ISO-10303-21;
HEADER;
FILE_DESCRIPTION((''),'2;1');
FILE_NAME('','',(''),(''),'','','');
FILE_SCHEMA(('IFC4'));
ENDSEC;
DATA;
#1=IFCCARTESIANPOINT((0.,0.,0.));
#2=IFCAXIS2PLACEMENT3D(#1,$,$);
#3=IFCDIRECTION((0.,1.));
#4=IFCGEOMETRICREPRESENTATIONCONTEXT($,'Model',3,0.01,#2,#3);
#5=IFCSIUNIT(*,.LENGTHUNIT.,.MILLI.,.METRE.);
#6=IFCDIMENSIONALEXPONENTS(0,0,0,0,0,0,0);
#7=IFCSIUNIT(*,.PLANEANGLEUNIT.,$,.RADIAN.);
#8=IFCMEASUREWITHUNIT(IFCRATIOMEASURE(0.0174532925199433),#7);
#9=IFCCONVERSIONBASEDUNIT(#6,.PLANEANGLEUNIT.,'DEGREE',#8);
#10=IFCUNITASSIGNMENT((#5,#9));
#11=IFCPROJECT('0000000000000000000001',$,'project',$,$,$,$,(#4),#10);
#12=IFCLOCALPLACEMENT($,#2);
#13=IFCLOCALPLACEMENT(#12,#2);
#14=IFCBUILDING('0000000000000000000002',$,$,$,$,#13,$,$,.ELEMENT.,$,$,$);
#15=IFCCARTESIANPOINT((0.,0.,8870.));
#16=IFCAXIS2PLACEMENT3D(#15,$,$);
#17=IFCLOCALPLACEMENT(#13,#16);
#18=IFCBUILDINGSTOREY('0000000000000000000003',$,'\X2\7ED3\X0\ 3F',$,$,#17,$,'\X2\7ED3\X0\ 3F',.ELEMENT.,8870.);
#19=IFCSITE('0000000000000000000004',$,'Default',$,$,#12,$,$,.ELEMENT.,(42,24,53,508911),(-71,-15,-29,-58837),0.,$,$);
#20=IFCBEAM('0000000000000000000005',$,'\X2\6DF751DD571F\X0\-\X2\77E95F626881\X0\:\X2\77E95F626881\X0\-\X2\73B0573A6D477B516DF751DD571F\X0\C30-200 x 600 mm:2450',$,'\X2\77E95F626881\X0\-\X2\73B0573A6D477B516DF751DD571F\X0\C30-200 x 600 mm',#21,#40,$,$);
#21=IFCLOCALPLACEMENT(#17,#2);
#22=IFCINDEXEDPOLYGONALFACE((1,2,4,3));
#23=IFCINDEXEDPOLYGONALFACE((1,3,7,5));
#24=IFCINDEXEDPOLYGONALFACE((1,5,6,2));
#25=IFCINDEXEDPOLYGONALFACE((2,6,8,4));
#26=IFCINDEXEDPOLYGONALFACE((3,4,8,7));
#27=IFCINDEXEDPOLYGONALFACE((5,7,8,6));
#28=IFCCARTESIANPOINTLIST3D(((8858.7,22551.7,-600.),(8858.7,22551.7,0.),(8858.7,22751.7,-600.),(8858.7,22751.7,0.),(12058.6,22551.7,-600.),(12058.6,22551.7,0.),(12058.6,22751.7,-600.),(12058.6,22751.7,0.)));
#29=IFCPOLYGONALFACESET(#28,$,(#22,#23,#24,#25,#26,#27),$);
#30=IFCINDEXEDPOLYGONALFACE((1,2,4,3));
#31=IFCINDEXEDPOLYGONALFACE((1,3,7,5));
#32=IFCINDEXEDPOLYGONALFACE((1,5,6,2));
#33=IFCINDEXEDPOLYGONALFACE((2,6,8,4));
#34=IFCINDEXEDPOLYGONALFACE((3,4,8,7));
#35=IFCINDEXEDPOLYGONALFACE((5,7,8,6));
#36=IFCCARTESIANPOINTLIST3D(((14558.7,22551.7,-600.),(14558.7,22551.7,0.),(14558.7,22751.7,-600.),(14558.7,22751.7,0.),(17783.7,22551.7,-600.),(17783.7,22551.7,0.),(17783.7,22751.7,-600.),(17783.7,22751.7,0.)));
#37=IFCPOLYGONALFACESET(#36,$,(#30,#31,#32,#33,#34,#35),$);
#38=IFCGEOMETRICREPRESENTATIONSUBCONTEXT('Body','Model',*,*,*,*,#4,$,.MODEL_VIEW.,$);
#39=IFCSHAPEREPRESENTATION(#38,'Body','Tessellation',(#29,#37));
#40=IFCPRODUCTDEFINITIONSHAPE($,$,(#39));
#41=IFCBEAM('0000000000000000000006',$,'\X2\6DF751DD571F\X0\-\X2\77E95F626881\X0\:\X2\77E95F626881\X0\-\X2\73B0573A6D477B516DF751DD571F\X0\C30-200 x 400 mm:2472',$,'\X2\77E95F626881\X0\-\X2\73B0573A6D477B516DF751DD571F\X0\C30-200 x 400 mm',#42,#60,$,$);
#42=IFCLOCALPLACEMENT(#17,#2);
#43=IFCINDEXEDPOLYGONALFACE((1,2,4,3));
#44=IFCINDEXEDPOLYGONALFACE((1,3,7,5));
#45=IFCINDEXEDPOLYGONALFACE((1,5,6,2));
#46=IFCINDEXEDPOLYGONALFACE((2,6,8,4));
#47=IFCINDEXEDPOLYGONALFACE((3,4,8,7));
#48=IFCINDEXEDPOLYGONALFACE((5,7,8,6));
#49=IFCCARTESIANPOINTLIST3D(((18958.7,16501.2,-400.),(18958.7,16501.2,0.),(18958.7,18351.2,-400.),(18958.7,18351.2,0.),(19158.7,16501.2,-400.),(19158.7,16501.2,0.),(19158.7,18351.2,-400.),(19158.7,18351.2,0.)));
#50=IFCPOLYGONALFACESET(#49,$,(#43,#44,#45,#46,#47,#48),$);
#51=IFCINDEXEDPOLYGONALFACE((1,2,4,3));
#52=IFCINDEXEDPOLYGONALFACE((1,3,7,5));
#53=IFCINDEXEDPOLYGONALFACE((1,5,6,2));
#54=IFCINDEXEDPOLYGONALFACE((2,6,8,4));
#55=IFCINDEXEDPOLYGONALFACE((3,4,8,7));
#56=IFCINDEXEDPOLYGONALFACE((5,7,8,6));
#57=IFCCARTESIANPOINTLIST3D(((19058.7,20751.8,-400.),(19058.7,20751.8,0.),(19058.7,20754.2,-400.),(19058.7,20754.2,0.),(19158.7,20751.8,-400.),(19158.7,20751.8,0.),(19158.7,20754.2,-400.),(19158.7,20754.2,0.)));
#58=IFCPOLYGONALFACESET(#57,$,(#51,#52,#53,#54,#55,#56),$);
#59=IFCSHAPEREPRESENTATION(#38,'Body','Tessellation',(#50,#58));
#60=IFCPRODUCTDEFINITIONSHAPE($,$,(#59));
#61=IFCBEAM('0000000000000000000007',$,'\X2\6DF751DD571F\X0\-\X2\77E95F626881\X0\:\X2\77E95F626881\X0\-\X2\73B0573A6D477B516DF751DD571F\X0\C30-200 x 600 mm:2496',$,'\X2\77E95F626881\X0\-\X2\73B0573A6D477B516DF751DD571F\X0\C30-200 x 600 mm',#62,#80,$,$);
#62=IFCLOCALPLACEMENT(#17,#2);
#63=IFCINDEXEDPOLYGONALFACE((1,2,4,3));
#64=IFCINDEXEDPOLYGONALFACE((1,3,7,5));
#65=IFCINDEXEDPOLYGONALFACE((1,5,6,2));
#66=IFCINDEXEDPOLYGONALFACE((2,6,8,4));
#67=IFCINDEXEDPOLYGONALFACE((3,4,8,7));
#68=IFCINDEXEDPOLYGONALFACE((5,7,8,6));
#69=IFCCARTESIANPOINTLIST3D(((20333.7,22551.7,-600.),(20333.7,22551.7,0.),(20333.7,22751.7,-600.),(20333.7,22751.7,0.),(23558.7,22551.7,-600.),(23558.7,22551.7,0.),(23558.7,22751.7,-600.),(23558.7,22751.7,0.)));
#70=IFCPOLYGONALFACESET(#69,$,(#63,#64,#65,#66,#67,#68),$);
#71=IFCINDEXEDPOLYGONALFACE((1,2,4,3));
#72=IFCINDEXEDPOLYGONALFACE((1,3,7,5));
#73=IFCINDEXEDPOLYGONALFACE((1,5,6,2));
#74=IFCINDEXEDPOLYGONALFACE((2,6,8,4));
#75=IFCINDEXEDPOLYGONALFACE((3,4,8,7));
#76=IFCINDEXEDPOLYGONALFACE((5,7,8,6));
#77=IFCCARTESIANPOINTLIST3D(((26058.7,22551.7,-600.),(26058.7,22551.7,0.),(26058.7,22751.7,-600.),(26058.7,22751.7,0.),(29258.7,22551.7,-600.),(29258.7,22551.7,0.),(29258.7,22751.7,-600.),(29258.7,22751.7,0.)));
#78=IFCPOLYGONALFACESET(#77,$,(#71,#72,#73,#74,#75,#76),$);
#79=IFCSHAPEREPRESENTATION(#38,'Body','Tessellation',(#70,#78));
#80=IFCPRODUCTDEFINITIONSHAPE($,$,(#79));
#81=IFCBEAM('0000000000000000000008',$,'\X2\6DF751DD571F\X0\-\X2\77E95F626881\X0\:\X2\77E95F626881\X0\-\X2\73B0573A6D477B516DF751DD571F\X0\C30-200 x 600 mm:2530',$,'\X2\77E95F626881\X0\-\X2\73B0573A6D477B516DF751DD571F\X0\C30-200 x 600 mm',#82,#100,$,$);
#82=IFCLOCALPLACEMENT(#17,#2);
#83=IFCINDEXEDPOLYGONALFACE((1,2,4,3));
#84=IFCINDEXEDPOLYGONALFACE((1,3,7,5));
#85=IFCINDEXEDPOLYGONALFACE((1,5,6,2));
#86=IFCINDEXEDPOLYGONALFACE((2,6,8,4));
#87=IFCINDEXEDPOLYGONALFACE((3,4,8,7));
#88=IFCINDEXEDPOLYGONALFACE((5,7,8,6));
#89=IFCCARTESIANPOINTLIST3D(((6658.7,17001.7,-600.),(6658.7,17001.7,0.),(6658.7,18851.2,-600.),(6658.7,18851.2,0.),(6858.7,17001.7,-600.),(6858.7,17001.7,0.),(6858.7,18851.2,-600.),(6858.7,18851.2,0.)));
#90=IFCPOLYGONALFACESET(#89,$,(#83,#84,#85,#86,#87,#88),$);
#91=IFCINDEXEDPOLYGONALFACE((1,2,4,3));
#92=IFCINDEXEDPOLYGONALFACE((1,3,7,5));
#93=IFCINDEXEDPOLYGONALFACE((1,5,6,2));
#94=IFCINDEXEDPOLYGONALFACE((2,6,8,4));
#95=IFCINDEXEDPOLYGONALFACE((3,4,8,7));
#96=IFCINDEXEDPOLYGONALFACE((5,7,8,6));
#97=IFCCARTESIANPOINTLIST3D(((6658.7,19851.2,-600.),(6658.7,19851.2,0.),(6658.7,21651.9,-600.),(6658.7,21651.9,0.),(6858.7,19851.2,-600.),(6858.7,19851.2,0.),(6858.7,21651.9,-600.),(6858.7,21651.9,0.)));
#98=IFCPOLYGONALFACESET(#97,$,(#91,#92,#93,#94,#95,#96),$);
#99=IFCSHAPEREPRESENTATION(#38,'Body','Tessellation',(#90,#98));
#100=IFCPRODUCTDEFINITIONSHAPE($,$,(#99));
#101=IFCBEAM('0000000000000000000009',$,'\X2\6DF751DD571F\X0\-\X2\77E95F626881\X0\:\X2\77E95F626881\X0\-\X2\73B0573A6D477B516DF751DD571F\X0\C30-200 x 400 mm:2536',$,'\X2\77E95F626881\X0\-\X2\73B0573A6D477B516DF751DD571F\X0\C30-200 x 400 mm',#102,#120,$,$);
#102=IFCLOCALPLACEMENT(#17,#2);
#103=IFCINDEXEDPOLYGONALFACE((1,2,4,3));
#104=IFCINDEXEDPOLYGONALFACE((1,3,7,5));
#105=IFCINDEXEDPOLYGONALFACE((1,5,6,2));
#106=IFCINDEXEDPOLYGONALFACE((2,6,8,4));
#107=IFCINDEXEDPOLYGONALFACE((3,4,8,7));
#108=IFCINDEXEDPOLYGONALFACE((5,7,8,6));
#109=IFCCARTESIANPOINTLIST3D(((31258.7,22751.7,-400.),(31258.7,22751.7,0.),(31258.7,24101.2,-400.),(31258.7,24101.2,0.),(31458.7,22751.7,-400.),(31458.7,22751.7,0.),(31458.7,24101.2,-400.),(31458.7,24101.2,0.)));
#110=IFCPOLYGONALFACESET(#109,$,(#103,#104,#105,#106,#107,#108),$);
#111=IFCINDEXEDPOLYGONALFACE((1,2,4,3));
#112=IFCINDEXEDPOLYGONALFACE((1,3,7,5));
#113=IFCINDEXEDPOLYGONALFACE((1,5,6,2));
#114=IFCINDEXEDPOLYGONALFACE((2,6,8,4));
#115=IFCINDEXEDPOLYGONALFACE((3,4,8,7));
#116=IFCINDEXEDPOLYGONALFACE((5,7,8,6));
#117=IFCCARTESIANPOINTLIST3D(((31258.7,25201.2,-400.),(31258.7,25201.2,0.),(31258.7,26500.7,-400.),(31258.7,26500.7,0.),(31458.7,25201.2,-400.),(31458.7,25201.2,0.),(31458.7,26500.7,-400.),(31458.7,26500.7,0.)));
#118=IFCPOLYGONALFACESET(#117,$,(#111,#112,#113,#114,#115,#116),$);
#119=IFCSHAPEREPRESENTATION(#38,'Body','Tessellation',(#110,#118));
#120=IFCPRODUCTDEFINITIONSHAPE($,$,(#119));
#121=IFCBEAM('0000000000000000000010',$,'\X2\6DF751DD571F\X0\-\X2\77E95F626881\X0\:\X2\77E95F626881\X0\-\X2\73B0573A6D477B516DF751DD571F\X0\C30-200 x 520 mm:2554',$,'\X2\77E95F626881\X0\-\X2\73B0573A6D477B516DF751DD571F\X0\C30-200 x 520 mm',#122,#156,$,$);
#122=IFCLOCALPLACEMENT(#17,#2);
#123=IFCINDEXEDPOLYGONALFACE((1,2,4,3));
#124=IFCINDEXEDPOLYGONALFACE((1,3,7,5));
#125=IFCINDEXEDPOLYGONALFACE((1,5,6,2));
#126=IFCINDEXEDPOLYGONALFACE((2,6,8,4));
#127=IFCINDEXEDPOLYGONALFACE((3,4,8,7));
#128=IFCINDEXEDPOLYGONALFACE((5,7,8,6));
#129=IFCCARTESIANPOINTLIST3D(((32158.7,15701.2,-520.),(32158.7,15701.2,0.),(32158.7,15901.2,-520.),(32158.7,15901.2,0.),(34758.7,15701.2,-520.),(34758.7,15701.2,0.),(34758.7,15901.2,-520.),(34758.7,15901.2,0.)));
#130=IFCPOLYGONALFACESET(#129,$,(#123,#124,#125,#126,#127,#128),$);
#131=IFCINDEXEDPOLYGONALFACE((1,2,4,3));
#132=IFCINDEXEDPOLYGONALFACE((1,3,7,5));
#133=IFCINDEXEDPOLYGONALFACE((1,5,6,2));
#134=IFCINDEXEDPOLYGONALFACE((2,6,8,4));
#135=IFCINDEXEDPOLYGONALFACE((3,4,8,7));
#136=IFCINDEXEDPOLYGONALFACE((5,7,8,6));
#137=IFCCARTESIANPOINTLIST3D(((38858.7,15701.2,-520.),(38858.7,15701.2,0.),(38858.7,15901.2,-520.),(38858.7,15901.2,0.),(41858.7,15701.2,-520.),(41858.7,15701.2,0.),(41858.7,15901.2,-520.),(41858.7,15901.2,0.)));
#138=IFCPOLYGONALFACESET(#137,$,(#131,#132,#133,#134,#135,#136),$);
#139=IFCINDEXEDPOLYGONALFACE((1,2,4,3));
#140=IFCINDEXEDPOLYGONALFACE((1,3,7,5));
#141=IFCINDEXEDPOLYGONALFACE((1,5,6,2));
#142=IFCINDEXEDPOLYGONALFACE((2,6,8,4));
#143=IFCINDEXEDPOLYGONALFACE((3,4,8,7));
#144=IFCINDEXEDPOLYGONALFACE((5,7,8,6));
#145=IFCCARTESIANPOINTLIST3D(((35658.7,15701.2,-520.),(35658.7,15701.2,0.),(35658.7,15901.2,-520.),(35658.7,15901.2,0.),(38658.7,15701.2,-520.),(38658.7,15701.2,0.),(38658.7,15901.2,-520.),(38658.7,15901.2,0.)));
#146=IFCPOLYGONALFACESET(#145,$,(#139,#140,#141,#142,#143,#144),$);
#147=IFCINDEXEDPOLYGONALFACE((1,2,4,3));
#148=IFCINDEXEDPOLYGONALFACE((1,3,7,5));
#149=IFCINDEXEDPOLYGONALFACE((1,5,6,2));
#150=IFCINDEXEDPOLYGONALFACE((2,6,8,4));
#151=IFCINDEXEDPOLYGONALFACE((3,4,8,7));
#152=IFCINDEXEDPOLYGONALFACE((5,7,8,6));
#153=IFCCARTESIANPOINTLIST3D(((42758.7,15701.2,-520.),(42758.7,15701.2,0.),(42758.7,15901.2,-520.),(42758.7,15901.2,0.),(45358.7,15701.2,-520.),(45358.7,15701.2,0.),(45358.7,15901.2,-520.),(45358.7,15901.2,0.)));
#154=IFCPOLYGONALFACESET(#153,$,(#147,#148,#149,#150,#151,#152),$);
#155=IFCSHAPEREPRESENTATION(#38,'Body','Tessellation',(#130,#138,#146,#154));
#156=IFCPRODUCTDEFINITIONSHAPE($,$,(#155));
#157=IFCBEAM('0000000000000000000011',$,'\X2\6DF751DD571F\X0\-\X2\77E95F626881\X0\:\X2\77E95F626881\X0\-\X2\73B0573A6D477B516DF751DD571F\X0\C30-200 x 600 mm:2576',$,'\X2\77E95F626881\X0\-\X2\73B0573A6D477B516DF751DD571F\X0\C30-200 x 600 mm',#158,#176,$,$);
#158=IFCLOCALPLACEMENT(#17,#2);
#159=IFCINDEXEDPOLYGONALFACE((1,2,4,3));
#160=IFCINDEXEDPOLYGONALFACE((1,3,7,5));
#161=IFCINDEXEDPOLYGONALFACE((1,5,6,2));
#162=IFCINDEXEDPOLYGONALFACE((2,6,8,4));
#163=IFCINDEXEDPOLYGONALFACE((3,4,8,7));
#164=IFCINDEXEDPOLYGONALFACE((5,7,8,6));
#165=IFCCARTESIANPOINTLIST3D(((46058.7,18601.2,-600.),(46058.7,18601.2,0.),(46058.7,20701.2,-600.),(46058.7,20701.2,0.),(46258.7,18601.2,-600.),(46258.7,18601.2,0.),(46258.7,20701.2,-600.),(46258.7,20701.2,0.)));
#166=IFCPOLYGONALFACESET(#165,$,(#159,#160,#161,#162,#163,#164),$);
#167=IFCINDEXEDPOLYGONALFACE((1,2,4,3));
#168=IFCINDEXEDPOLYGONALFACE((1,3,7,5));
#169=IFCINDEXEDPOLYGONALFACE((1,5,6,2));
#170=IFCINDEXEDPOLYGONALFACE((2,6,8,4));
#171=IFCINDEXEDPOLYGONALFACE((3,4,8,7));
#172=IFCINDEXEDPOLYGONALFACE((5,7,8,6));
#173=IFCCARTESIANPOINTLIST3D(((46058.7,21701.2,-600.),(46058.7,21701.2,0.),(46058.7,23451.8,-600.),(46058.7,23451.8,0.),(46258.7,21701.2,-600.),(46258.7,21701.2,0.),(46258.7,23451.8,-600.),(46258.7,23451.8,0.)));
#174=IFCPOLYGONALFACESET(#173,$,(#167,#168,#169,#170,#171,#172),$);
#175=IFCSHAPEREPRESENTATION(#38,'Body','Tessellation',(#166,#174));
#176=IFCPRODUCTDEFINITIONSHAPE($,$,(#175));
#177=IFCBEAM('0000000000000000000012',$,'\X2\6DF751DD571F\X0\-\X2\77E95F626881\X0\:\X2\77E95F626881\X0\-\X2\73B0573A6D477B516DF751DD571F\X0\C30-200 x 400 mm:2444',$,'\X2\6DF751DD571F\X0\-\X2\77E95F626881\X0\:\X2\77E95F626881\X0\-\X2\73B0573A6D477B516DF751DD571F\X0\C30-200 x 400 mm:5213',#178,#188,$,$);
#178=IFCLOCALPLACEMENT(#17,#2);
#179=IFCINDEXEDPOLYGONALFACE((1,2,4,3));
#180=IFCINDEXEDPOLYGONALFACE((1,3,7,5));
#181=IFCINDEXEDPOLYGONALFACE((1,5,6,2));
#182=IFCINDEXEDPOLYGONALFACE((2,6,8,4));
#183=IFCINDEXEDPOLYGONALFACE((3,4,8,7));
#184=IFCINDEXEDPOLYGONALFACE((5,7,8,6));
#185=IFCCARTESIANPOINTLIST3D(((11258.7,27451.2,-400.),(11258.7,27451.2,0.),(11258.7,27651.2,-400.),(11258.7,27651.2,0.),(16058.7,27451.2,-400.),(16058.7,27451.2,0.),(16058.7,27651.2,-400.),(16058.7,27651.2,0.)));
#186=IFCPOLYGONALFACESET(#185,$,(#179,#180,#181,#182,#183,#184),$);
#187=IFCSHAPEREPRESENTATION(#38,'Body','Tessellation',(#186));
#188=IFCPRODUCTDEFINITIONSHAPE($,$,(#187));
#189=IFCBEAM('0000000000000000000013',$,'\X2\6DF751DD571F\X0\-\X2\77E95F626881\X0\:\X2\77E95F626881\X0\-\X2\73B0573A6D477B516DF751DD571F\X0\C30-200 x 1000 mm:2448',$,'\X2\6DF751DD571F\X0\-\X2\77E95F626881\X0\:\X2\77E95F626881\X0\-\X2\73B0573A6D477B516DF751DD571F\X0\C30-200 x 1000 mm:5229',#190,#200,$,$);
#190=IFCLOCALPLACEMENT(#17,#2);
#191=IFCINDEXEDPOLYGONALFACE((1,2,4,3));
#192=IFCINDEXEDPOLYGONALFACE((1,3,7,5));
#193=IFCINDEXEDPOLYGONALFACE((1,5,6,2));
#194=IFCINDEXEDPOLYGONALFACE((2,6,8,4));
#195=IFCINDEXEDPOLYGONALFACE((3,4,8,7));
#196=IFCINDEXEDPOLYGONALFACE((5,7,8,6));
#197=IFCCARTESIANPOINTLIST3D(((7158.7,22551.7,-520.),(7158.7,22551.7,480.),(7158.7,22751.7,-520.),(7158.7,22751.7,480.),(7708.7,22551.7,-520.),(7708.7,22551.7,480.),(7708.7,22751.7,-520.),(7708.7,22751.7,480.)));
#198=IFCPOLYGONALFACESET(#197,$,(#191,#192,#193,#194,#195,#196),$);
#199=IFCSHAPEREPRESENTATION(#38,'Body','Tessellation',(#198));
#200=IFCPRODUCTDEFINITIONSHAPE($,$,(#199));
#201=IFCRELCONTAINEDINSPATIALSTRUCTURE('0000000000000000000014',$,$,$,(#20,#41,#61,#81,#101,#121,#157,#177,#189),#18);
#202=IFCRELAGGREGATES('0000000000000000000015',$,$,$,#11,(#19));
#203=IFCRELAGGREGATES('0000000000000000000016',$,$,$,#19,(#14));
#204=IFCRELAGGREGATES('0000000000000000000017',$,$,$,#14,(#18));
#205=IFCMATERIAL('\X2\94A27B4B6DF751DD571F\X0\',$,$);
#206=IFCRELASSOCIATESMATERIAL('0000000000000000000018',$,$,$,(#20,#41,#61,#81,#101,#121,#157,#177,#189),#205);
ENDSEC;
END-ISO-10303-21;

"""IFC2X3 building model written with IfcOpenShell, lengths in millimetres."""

from ifc_helpers import new_model, entity, si_unit, converted_unit, direction, frame, frame_2d, origin, origin_2d_with_axis, place, context, subcontext, project, spatial, rectangle, extrude, source, transform, mapped, material, element, save


model = new_model("IFC2X3")

# Units and contexts
model_context = context("Model", 3, precision=0.01, world=origin(), true_north=direction((0.0, 1.0)))
body_context = subcontext(model_context, "Body", "Model", "MODEL_VIEW")
ifc_project = project(units=[si_unit("LENGTHUNIT", "METRE", prefix="MILLI"), converted_unit("PLANEANGLEUNIT", "DEGREE", entity("IfcRatioMeasure", 0.0174532925199433), si_unit("PLANEANGLEUNIT", "RADIAN"), dimensions=[0, 0, 0, 0, 0, 0, 0])], contexts=[model_context])

# Site, building, storey
site_placement = place(None, origin())
site = spatial("IfcSite", under=ifc_project, at=site_placement, Name="Default", CompositionType="ELEMENT", RefLatitude=(42, 24, 53, 508911), RefLongitude=(-71, -15, -29, -58837), RefElevation=0.0)
building_placement = place(site_placement, origin())
building = spatial("IfcBuilding", under=site, at=building_placement, CompositionType="ELEMENT")
storey_placement = place(building_placement, frame((0.0, 0.0, 8870.0)))
storey = spatial("IfcBuildingStorey", under=building, at=storey_placement, Name="结 3F", LongName="结 3F", CompositionType="ELEMENT", Elevation=8870.0)

# Beams
ifc_material = material(Name="钢筋混凝土")
shared_shape_1 = source(origin(), body_context, "Body", "SweptSolid", [
    extrude(rectangle(XDim=3200.0, YDim=200.0, at=origin_2d_with_axis()), frame((10458.7, 22651.7, 8270.0), z_axis=(0.0, 0.0, 1.0), x_axis=(-1.0, 0.0, 0.0)), (0.0, 0.0, 1.0), 600.0),
    extrude(rectangle(XDim=3225.0, YDim=200.0, at=origin_2d_with_axis()), frame((16171.2, 22651.7, 8270.0), z_axis=(0.0, 0.0, 1.0), x_axis=(-1.0, 0.0, 0.0)), (0.0, 0.0, 1.0), 600.0),
])
beam_1_placement = place(storey_placement, frame((0.0, 0.0, -8870.0)))
element("IfcBeam", 1, at=beam_1_placement, inside=storey, material=ifc_material, Name="混凝土-矩形梁:矩形梁-现场浇筑混凝土C30-200 x 600 mm:2450", ObjectType="矩形梁-现场浇筑混凝土C30-200 x 600 mm", context=body_context, shape_type="MappedRepresentation", body=[
    mapped(shared_shape_1, transform((0.0, 0.0, 0.0), scale=1.0)),
])
shared_shape_2 = source(origin(), body_context, "Body", "SweptSolid", [
    extrude(rectangle(XDim=1850.0, YDim=200.0, at=frame_2d((0.0, 0.0), x_axis=(1.0, 0.0))), frame((19058.7, 17426.2, 8470.0), z_axis=(0.0, 0.0, 1.0), x_axis=(0.0, -1.0, 0.0)), (0.0, 0.0, 1.0), 400.0),
    extrude(rectangle(XDim=100.0, YDim=2.4, at=origin_2d_with_axis()), frame((19108.7, 20753.0, 8470.0), z_axis=(0.0, 0.0, 1.0), x_axis=(-1.0, 0.0, 0.0)), (0.0, 0.0, 1.0), 400.0),
])
beam_2_placement = place(storey_placement, frame((0.0, 0.0, -8870.0)))
element("IfcBeam", 2, at=beam_2_placement, inside=storey, material=ifc_material, Name="混凝土-矩形梁:矩形梁-现场浇筑混凝土C30-200 x 400 mm:2472", ObjectType="矩形梁-现场浇筑混凝土C30-200 x 400 mm", context=body_context, shape_type="MappedRepresentation", body=[
    mapped(shared_shape_2, transform((0.0, 0.0, 0.0), scale=1.0)),
])
shared_shape_3 = source(origin(), body_context, "Body", "SweptSolid", [
    extrude(rectangle(XDim=3225.0, YDim=200.0, at=origin_2d_with_axis()), frame((21946.2, 22651.7, 8270.0)), (0.0, 0.0, 1.0), 600.0),
    extrude(rectangle(XDim=3200.0, YDim=200.0, at=frame_2d((0.0, 0.0), x_axis=(1.0, 0.0))), frame((27658.7, 22651.7, 8270.0)), (0.0, 0.0, 1.0), 600.0),
])
beam_3_placement = place(storey_placement, frame((0.0, 0.0, -8870.0)))
element("IfcBeam", 3, at=beam_3_placement, inside=storey, material=ifc_material, Name="混凝土-矩形梁:矩形梁-现场浇筑混凝土C30-200 x 600 mm:2496", ObjectType="矩形梁-现场浇筑混凝土C30-200 x 600 mm", context=body_context, shape_type="MappedRepresentation", body=[
    mapped(shared_shape_3, transform((0.0, 0.0, 0.0), scale=1.0)),
])
shared_shape_4 = source(origin(), body_context, "Body", "SweptSolid", [
    extrude(rectangle(XDim=1849.5, YDim=200.0, at=frame_2d((0.0, 0.0), x_axis=(1.0, 0.0))), frame((6758.7, 17926.5, 8270.0), z_axis=(0.0, 0.0, 1.0), x_axis=(0.0, 1.0, 0.0)), (0.0, 0.0, 1.0), 600.0),
    extrude(rectangle(XDim=1800.7, YDim=200.0, at=frame_2d((0.0, 0.0), x_axis=(1.0, 0.0))), frame((6758.7, 20751.6, 8270.0), z_axis=(0.0, 0.0, 1.0), x_axis=(0.0, -1.0, 0.0)), (0.0, 0.0, 1.0), 600.0),
])
beam_4_placement = place(storey_placement, frame((0.0, 0.0, -8870.0)))
element("IfcBeam", 4, at=beam_4_placement, inside=storey, material=ifc_material, Name="混凝土-矩形梁:矩形梁-现场浇筑混凝土C30-200 x 600 mm:2530", ObjectType="矩形梁-现场浇筑混凝土C30-200 x 600 mm", context=body_context, shape_type="MappedRepresentation", body=[
    mapped(shared_shape_4, transform((0.0, 0.0, 0.0), scale=1.0)),
])
shared_shape_5 = source(origin(), body_context, "Body", "SweptSolid", [
    extrude(rectangle(XDim=1349.5, YDim=200.0, at=frame_2d((0.0, 0.0), x_axis=(1.0, 0.0))), frame((31358.7, 23426.5, 8470.0), z_axis=(0.0, 0.0, 1.0), x_axis=(0.0, 1.0, 0.0)), (0.0, 0.0, 1.0), 400.0),
    extrude(rectangle(XDim=1299.5, YDim=200.0, at=frame_2d((0.0, 0.0), x_axis=(1.0, 0.0))), frame((31358.7, 25851.0, 8470.0), z_axis=(0.0, 0.0, 1.0), x_axis=(0.0, -1.0, 0.0)), (0.0, 0.0, 1.0), 400.0),
])
beam_5_placement = place(storey_placement, frame((0.0, 0.0, -8870.0)))
element("IfcBeam", 5, at=beam_5_placement, inside=storey, material=ifc_material, Name="混凝土-矩形梁:矩形梁-现场浇筑混凝土C30-200 x 400 mm:2536", ObjectType="矩形梁-现场浇筑混凝土C30-200 x 400 mm", context=body_context, shape_type="MappedRepresentation", body=[
    mapped(shared_shape_5, transform((0.0, 0.0, 0.0), scale=1.0)),
])
shared_shape_6 = source(origin(), body_context, "Body", "SweptSolid", [
    extrude(rectangle(XDim=2600.0, YDim=200.0, at=frame_2d((0.0, 0.0), x_axis=(1.0, 0.0))), frame((33458.7, 15801.2, 8350.0), z_axis=(0.0, 0.0, 1.0), x_axis=(-1.0, 0.0, 0.0)), (0.0, 0.0, 1.0), 520.0),
    extrude(rectangle(XDim=3000.0, YDim=200.0, at=origin_2d_with_axis()), frame((40358.7, 15801.2, 8350.0)), (0.0, 0.0, 1.0), 520.0),
    extrude(rectangle(XDim=3000.0, YDim=200.0, at=frame_2d((0.0, 0.0), x_axis=(1.0, 0.0))), frame((37158.7, 15801.2, 8350.0), z_axis=(0.0, 0.0, 1.0), x_axis=(-1.0, 0.0, 0.0)), (0.0, 0.0, 1.0), 520.0),
    extrude(rectangle(XDim=2600.0, YDim=200.0, at=frame_2d((0.0, 0.0), x_axis=(1.0, 0.0))), frame((44058.7, 15801.2, 8350.0)), (0.0, 0.0, 1.0), 520.0),
])
beam_6_placement = place(storey_placement, frame((0.0, 0.0, -8870.0)))
element("IfcBeam", 6, at=beam_6_placement, inside=storey, material=ifc_material, Name="混凝土-矩形梁:矩形梁-现场浇筑混凝土C30-200 x 520 mm:2554", ObjectType="矩形梁-现场浇筑混凝土C30-200 x 520 mm", context=body_context, shape_type="MappedRepresentation", body=[
    mapped(shared_shape_6, transform((0.0, 0.0, 0.0), scale=1.0)),
])
shared_shape_7 = source(origin(), body_context, "Body", "SweptSolid", [
    extrude(rectangle(XDim=2100.0, YDim=200.0, at=frame_2d((0.0, 0.0), x_axis=(1.0, 0.0))), frame((46158.7, 19651.2, 8270.0), z_axis=(0.0, 0.0, 1.0), x_axis=(0.0, 1.0, 0.0)), (0.0, 0.0, 1.0), 600.0),
    extrude(rectangle(XDim=1750.6, YDim=200.0, at=frame_2d((0.0, 0.0), x_axis=(1.0, 0.0))), frame((46158.7, 22576.5, 8270.0), z_axis=(0.0, 0.0, 1.0), x_axis=(0.0, 1.0, 0.0)), (0.0, 0.0, 1.0), 600.0),
])
beam_7_placement = place(storey_placement, frame((0.0, 0.0, -8870.0)))
element("IfcBeam", 7, at=beam_7_placement, inside=storey, material=ifc_material, Name="混凝土-矩形梁:矩形梁-现场浇筑混凝土C30-200 x 600 mm:2576", ObjectType="矩形梁-现场浇筑混凝土C30-200 x 600 mm", context=body_context, shape_type="MappedRepresentation", body=[
    mapped(shared_shape_7, transform((0.0, 0.0, 0.0), scale=1.0)),
])
beam_8_placement = place(storey_placement, frame((11158.7, 27551.2, 0.0)))
element("IfcBeam", 8, at=beam_8_placement, inside=storey, material=ifc_material, Name="混凝土-矩形梁:矩形梁-现场浇筑混凝土C30-200 x 400 mm:2444", ObjectType="混凝土-矩形梁:矩形梁-现场浇筑混凝土C30-200 x 400 mm:5213", context=body_context, shape_type="SweptSolid", body=[
    extrude(rectangle(XDim=400.0, YDim=200.0, at=frame_2d((0.0, 0.0), x_axis=(1.0, 0.0))), frame((100.0, 0.0, -200.0), z_axis=(1.0, 0.0, 0.0), x_axis=(0.0, 0.0, -1.0)), (0.0, 0.0, 1.0), 4800.0),
])
beam_9_placement = place(storey_placement, frame((6758.7, 22651.7, 480.0)))
element("IfcBeam", 9, at=beam_9_placement, inside=storey, material=ifc_material, Name="混凝土-矩形梁:矩形梁-现场浇筑混凝土C30-200 x 1000 mm:2448", ObjectType="混凝土-矩形梁:矩形梁-现场浇筑混凝土C30-200 x 1000 mm:5229", context=body_context, shape_type="SweptSolid", body=[
    extrude(rectangle(XDim=1000.0, YDim=200.0, at=frame_2d((0.0, 0.0), x_axis=(1.0, 0.0))), frame((400.0, 0.0, -500.0), z_axis=(1.0, 0.0, 0.0), x_axis=(0.0, 0.0, -1.0)), (0.0, 0.0, 1.0), 550.0),
])

save(model, "model.ifc")
